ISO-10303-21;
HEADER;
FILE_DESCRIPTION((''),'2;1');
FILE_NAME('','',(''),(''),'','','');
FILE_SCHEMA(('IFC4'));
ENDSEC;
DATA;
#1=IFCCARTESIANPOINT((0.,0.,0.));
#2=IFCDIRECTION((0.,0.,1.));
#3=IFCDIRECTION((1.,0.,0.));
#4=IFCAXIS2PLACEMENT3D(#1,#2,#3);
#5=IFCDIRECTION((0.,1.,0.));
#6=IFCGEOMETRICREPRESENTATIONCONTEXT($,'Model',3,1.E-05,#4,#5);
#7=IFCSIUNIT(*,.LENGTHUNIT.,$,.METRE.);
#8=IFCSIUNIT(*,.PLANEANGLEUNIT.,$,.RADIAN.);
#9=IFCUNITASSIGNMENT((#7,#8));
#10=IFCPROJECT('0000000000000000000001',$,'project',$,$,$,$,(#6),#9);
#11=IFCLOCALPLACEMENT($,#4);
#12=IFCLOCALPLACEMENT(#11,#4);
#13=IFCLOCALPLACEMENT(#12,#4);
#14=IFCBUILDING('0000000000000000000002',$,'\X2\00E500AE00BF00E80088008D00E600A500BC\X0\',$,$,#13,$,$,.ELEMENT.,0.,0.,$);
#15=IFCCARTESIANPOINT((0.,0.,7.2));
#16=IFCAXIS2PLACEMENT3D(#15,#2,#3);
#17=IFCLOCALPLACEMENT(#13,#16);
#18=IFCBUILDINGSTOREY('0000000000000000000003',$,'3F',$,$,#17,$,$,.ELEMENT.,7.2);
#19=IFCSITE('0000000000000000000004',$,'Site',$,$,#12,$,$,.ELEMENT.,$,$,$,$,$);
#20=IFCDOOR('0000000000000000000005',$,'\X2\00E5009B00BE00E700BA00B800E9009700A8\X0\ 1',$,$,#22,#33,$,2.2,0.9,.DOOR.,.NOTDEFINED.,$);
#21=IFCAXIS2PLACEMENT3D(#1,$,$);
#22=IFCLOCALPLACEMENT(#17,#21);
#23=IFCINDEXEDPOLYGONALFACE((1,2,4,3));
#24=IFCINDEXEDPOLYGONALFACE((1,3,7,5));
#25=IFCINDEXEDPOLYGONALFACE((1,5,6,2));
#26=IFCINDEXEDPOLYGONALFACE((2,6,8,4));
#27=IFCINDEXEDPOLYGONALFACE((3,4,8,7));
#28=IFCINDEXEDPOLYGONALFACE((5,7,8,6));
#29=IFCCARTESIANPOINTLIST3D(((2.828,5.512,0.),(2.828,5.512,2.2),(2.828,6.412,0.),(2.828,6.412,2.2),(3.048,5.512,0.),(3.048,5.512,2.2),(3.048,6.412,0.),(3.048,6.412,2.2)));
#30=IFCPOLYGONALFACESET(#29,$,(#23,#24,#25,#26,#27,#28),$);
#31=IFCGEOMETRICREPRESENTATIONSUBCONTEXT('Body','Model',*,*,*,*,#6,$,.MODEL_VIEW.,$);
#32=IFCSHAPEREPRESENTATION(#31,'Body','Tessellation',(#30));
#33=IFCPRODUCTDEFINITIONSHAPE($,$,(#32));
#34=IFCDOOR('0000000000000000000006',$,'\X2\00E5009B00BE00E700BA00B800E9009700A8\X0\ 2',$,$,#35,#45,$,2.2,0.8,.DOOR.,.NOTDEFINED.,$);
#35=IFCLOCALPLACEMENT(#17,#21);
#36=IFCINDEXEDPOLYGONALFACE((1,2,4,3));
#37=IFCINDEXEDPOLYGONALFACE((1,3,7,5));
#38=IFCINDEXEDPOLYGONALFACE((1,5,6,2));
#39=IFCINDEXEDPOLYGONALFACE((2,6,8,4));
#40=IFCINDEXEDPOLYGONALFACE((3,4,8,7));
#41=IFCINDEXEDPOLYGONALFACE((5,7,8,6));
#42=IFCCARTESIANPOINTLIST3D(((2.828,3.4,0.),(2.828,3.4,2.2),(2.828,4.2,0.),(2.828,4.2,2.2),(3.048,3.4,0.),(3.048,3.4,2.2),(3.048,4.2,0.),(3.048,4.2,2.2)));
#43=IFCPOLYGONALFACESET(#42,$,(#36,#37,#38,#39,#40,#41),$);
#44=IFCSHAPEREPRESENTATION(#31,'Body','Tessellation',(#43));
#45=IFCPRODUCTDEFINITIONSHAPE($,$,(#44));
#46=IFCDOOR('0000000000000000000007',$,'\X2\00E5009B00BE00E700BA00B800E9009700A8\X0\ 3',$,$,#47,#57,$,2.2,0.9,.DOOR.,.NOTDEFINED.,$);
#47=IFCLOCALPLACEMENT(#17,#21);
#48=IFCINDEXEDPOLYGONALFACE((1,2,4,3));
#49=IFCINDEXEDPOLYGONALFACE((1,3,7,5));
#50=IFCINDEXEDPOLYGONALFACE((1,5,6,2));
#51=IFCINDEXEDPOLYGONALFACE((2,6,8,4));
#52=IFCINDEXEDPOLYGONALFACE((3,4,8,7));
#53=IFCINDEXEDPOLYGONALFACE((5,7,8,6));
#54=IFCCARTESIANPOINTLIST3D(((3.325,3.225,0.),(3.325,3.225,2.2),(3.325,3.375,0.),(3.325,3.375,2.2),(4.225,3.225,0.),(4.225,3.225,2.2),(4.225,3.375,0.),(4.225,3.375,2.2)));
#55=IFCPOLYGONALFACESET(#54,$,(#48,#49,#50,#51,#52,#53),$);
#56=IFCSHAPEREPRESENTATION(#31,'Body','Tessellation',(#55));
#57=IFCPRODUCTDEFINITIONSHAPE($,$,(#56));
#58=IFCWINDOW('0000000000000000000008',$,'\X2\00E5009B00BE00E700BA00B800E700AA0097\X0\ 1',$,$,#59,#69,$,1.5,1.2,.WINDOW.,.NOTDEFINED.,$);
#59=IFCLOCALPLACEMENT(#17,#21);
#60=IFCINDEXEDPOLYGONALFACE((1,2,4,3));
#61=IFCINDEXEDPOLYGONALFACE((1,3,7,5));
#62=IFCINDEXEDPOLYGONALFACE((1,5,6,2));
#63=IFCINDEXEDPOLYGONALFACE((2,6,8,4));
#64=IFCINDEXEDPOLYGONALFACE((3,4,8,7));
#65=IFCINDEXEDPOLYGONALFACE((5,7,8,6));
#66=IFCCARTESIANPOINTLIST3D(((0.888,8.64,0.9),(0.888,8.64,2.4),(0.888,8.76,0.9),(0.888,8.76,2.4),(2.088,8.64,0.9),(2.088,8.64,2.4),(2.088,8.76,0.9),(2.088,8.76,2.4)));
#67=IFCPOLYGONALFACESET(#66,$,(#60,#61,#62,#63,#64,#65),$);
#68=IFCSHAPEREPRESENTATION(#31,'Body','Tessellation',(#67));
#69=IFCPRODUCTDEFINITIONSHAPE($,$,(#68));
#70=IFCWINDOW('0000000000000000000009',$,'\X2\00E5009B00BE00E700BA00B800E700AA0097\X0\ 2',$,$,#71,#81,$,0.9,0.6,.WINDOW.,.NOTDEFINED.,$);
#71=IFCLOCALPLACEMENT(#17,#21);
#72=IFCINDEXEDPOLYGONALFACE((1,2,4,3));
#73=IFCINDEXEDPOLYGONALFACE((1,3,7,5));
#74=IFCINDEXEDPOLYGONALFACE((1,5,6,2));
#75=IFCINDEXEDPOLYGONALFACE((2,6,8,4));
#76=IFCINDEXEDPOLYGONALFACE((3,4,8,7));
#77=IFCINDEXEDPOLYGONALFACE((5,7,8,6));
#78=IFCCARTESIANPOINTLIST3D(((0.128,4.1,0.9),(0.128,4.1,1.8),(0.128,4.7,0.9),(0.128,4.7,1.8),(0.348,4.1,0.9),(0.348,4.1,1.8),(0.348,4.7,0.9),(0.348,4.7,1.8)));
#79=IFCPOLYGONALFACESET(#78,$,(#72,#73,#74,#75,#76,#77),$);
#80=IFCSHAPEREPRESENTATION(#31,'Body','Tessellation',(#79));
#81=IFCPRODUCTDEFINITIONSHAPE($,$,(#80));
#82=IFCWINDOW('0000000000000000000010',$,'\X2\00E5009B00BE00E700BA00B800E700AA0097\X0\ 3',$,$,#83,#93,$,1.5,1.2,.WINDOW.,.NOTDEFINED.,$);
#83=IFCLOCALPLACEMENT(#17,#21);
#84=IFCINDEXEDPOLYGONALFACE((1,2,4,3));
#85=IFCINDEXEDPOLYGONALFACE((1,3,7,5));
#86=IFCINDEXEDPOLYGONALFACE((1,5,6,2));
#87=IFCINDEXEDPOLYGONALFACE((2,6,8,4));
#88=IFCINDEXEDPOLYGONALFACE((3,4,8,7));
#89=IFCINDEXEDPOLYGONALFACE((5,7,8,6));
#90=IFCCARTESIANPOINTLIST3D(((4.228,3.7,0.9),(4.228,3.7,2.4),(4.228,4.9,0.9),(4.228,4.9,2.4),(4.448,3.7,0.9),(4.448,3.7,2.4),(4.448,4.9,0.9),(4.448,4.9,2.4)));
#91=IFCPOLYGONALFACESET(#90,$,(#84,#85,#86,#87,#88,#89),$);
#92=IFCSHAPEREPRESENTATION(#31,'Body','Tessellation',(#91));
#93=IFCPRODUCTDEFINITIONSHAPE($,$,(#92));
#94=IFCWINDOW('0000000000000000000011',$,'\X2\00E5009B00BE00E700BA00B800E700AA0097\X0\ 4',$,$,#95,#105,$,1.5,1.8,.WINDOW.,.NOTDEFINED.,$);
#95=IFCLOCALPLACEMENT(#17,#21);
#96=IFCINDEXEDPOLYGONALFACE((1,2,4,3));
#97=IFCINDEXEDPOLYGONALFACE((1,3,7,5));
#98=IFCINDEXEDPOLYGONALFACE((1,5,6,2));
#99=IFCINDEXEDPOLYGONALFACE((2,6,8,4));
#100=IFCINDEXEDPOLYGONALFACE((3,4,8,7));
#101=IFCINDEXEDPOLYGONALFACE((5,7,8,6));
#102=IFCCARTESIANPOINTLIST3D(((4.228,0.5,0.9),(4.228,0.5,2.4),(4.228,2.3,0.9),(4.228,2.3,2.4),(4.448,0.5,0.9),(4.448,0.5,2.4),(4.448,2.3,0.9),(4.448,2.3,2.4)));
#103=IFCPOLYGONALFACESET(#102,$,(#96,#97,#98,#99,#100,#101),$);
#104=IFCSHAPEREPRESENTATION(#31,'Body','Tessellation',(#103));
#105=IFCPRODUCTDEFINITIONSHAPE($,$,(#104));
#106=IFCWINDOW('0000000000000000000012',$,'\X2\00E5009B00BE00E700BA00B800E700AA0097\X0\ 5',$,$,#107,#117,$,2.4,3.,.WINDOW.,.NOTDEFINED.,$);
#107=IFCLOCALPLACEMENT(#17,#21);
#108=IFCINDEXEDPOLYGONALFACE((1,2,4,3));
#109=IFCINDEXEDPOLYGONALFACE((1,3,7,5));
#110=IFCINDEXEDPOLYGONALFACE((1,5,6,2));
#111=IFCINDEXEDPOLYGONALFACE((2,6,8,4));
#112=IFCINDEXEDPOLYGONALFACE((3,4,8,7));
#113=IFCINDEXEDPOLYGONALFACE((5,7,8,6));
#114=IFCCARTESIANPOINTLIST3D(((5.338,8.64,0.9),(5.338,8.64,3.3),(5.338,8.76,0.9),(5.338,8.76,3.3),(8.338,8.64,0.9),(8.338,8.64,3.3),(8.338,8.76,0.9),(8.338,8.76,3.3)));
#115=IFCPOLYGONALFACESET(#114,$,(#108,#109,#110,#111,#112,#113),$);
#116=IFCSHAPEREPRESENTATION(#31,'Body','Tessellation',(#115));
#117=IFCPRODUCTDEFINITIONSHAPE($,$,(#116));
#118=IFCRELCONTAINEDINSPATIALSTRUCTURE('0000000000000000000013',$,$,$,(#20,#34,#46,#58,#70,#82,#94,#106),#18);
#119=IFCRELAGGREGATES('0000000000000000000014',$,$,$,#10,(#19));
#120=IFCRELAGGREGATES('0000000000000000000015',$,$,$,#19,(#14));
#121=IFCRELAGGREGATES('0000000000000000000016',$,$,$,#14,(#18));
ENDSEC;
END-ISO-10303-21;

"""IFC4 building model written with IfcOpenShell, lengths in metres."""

from ifc_helpers import new_model, si_unit, direction, frame, frame_2d, origin_with_axes, place, context, subcontext, project, spatial, rectangle, extrude, element, save


model = new_model("IFC4")

# Units and contexts
model_context = context("Model", 3, precision=1e-05, world=origin_with_axes(), true_north=direction((0.0, 1.0, 0.0)))
body_context = subcontext(model_context, "Body", "Model", "MODEL_VIEW")
ifc_project = project(units=[si_unit("LENGTHUNIT", "METRE"), si_unit("PLANEANGLEUNIT", "RADIAN")], contexts=[model_context])

# Site, building, storey
placement = place(None, origin_with_axes())
site_placement = place(placement, origin_with_axes())
site = spatial("IfcSite", under=ifc_project, at=site_placement, Name="Site", CompositionType="ELEMENT")
building_placement = place(site_placement, origin_with_axes())
building = spatial("IfcBuilding", under=site, at=building_placement, Name="å®¿è\u0088\u008dæ¥¼", CompositionType="ELEMENT", ElevationOfRefHeight=0.0, ElevationOfTerrain=0.0)
storey_placement = place(building_placement, frame((0.0, 0.0, 7.2), z_axis=(0.0, 0.0, 1.0), x_axis=(1.0, 0.0, 0.0)))
storey = spatial("IfcBuildingStorey", under=building, at=storey_placement, Name="3F", CompositionType="ELEMENT", Elevation=7.2)

# Doors
door_1_placement = place(storey_placement, frame((2.938, 5.962, 0.0), z_axis=(0.0, 0.0, 1.0), x_axis=(0.0, 1.0, 0.0)))
element("IfcDoor", 1, at=door_1_placement, inside=storey, Name="å\u009b¾çº¸é\u0097¨ 1", OperationType="NOTDEFINED", OverallHeight=2.2, OverallWidth=0.9, PredefinedType="DOOR", context=body_context, shape_type="SweptSolid", body=[
    extrude(rectangle(XDim=0.9, YDim=0.22, at=frame_2d((0.0, 0.0), x_axis=(1.0, 0.0, 0.0))), frame((0.0, 0.0, 0.0), z_axis=(0.0, 0.0, 1.0)), (0.0, 0.0, 1.0), 2.2),
])
door_2_placement = place(storey_placement, frame((2.938, 3.8, 0.0), z_axis=(0.0, 0.0, 1.0), x_axis=(0.0, 1.0, 0.0)))
element("IfcDoor", 2, at=door_2_placement, inside=storey, Name="å\u009b¾çº¸é\u0097¨ 2", OperationType="NOTDEFINED", OverallHeight=2.2, OverallWidth=0.8, PredefinedType="DOOR", context=body_context, shape_type="SweptSolid", body=[
    extrude(rectangle(XDim=0.8, YDim=0.22, at=frame_2d((0.0, 0.0), x_axis=(1.0, 0.0, 0.0))), frame((0.0, 0.0, 0.0), z_axis=(0.0, 0.0, 1.0)), (0.0, 0.0, 1.0), 2.2),
])
door_3_placement = place(storey_placement, frame((3.775, 3.3, 0.0), z_axis=(0.0, 0.0, 1.0), x_axis=(1.0, 0.0, 0.0)))
element("IfcDoor", 3, at=door_3_placement, inside=storey, Name="å\u009b¾çº¸é\u0097¨ 3", OperationType="NOTDEFINED", OverallHeight=2.2, OverallWidth=0.9, PredefinedType="DOOR", context=body_context, shape_type="SweptSolid", body=[
    extrude(rectangle(XDim=0.9, YDim=0.15, at=frame_2d((0.0, 0.0), x_axis=(1.0, 0.0, 0.0))), frame((0.0, 0.0, 0.0), z_axis=(0.0, 0.0, 1.0)), (0.0, 0.0, 1.0), 2.2),
])

# Windows
window_1_placement = place(storey_placement, frame((1.488, 8.7, 0.9), z_axis=(0.0, 0.0, 1.0), x_axis=(1.0, 0.0, 0.0)))
element("IfcWindow", 4, at=window_1_placement, inside=storey, Name="å\u009b¾çº¸çª\u0097 1", OverallHeight=1.5, OverallWidth=1.2, PartitioningType="NOTDEFINED", PredefinedType="WINDOW", context=body_context, shape_type="SweptSolid", body=[
    extrude(rectangle(XDim=1.2, YDim=0.12, at=frame_2d((0.0, 0.0), x_axis=(1.0, 0.0, 0.0))), frame((0.0, 0.0, 0.0), z_axis=(0.0, 0.0, 1.0)), (0.0, 0.0, 1.0), 1.5),
])
window_2_placement = place(storey_placement, frame((0.238, 4.4, 0.9), z_axis=(0.0, 0.0, 1.0), x_axis=(0.0, 1.0, 0.0)))
element("IfcWindow", 5, at=window_2_placement, inside=storey, Name="å\u009b¾çº¸çª\u0097 2", OverallHeight=0.9, OverallWidth=0.6, PartitioningType="NOTDEFINED", PredefinedType="WINDOW", context=body_context, shape_type="SweptSolid", body=[
    extrude(rectangle(XDim=0.6, YDim=0.22, at=frame_2d((0.0, 0.0), x_axis=(1.0, 0.0, 0.0))), frame((0.0, 0.0, 0.0), z_axis=(0.0, 0.0, 1.0)), (0.0, 0.0, 1.0), 0.9),
])
window_3_placement = place(storey_placement, frame((4.338, 4.3, 0.9), z_axis=(0.0, 0.0, 1.0), x_axis=(0.0, 1.0, 0.0)))
element("IfcWindow", 6, at=window_3_placement, inside=storey, Name="å\u009b¾çº¸çª\u0097 3", OverallHeight=1.5, OverallWidth=1.2, PartitioningType="NOTDEFINED", PredefinedType="WINDOW", context=body_context, shape_type="SweptSolid", body=[
    extrude(rectangle(XDim=1.2, YDim=0.22, at=frame_2d((0.0, 0.0), x_axis=(1.0, 0.0, 0.0))), frame((0.0, 0.0, 0.0), z_axis=(0.0, 0.0, 1.0)), (0.0, 0.0, 1.0), 1.5),
])
window_4_placement = place(storey_placement, frame((4.338, 1.4, 0.9), z_axis=(0.0, 0.0, 1.0), x_axis=(0.0, 1.0, 0.0)))
element("IfcWindow", 7, at=window_4_placement, inside=storey, Name="å\u009b¾çº¸çª\u0097 4", OverallHeight=1.5, OverallWidth=1.8, PartitioningType="NOTDEFINED", PredefinedType="WINDOW", context=body_context, shape_type="SweptSolid", body=[
    extrude(rectangle(XDim=1.8, YDim=0.22, at=frame_2d((0.0, 0.0), x_axis=(1.0, 0.0, 0.0))), frame((0.0, 0.0, 0.0), z_axis=(0.0, 0.0, 1.0)), (0.0, 0.0, 1.0), 1.5),
])
window_5_placement = place(storey_placement, frame((6.838, 8.7, 0.9), z_axis=(0.0, 0.0, 1.0), x_axis=(-1.0, 0.0, 0.0)))
element("IfcWindow", 8, at=window_5_placement, inside=storey, Name="å\u009b¾çº¸çª\u0097 5", OverallHeight=2.4, OverallWidth=3.0, PartitioningType="NOTDEFINED", PredefinedType="WINDOW", context=body_context, shape_type="SweptSolid", body=[
    extrude(rectangle(XDim=3.0, YDim=0.12, at=frame_2d((0.0, 0.0), x_axis=(1.0, 0.0, 0.0))), frame((0.0, 0.0, 0.0), z_axis=(0.0, 0.0, 1.0)), (0.0, 0.0, 1.0), 2.4),
])

save(model, "model.ifc")
